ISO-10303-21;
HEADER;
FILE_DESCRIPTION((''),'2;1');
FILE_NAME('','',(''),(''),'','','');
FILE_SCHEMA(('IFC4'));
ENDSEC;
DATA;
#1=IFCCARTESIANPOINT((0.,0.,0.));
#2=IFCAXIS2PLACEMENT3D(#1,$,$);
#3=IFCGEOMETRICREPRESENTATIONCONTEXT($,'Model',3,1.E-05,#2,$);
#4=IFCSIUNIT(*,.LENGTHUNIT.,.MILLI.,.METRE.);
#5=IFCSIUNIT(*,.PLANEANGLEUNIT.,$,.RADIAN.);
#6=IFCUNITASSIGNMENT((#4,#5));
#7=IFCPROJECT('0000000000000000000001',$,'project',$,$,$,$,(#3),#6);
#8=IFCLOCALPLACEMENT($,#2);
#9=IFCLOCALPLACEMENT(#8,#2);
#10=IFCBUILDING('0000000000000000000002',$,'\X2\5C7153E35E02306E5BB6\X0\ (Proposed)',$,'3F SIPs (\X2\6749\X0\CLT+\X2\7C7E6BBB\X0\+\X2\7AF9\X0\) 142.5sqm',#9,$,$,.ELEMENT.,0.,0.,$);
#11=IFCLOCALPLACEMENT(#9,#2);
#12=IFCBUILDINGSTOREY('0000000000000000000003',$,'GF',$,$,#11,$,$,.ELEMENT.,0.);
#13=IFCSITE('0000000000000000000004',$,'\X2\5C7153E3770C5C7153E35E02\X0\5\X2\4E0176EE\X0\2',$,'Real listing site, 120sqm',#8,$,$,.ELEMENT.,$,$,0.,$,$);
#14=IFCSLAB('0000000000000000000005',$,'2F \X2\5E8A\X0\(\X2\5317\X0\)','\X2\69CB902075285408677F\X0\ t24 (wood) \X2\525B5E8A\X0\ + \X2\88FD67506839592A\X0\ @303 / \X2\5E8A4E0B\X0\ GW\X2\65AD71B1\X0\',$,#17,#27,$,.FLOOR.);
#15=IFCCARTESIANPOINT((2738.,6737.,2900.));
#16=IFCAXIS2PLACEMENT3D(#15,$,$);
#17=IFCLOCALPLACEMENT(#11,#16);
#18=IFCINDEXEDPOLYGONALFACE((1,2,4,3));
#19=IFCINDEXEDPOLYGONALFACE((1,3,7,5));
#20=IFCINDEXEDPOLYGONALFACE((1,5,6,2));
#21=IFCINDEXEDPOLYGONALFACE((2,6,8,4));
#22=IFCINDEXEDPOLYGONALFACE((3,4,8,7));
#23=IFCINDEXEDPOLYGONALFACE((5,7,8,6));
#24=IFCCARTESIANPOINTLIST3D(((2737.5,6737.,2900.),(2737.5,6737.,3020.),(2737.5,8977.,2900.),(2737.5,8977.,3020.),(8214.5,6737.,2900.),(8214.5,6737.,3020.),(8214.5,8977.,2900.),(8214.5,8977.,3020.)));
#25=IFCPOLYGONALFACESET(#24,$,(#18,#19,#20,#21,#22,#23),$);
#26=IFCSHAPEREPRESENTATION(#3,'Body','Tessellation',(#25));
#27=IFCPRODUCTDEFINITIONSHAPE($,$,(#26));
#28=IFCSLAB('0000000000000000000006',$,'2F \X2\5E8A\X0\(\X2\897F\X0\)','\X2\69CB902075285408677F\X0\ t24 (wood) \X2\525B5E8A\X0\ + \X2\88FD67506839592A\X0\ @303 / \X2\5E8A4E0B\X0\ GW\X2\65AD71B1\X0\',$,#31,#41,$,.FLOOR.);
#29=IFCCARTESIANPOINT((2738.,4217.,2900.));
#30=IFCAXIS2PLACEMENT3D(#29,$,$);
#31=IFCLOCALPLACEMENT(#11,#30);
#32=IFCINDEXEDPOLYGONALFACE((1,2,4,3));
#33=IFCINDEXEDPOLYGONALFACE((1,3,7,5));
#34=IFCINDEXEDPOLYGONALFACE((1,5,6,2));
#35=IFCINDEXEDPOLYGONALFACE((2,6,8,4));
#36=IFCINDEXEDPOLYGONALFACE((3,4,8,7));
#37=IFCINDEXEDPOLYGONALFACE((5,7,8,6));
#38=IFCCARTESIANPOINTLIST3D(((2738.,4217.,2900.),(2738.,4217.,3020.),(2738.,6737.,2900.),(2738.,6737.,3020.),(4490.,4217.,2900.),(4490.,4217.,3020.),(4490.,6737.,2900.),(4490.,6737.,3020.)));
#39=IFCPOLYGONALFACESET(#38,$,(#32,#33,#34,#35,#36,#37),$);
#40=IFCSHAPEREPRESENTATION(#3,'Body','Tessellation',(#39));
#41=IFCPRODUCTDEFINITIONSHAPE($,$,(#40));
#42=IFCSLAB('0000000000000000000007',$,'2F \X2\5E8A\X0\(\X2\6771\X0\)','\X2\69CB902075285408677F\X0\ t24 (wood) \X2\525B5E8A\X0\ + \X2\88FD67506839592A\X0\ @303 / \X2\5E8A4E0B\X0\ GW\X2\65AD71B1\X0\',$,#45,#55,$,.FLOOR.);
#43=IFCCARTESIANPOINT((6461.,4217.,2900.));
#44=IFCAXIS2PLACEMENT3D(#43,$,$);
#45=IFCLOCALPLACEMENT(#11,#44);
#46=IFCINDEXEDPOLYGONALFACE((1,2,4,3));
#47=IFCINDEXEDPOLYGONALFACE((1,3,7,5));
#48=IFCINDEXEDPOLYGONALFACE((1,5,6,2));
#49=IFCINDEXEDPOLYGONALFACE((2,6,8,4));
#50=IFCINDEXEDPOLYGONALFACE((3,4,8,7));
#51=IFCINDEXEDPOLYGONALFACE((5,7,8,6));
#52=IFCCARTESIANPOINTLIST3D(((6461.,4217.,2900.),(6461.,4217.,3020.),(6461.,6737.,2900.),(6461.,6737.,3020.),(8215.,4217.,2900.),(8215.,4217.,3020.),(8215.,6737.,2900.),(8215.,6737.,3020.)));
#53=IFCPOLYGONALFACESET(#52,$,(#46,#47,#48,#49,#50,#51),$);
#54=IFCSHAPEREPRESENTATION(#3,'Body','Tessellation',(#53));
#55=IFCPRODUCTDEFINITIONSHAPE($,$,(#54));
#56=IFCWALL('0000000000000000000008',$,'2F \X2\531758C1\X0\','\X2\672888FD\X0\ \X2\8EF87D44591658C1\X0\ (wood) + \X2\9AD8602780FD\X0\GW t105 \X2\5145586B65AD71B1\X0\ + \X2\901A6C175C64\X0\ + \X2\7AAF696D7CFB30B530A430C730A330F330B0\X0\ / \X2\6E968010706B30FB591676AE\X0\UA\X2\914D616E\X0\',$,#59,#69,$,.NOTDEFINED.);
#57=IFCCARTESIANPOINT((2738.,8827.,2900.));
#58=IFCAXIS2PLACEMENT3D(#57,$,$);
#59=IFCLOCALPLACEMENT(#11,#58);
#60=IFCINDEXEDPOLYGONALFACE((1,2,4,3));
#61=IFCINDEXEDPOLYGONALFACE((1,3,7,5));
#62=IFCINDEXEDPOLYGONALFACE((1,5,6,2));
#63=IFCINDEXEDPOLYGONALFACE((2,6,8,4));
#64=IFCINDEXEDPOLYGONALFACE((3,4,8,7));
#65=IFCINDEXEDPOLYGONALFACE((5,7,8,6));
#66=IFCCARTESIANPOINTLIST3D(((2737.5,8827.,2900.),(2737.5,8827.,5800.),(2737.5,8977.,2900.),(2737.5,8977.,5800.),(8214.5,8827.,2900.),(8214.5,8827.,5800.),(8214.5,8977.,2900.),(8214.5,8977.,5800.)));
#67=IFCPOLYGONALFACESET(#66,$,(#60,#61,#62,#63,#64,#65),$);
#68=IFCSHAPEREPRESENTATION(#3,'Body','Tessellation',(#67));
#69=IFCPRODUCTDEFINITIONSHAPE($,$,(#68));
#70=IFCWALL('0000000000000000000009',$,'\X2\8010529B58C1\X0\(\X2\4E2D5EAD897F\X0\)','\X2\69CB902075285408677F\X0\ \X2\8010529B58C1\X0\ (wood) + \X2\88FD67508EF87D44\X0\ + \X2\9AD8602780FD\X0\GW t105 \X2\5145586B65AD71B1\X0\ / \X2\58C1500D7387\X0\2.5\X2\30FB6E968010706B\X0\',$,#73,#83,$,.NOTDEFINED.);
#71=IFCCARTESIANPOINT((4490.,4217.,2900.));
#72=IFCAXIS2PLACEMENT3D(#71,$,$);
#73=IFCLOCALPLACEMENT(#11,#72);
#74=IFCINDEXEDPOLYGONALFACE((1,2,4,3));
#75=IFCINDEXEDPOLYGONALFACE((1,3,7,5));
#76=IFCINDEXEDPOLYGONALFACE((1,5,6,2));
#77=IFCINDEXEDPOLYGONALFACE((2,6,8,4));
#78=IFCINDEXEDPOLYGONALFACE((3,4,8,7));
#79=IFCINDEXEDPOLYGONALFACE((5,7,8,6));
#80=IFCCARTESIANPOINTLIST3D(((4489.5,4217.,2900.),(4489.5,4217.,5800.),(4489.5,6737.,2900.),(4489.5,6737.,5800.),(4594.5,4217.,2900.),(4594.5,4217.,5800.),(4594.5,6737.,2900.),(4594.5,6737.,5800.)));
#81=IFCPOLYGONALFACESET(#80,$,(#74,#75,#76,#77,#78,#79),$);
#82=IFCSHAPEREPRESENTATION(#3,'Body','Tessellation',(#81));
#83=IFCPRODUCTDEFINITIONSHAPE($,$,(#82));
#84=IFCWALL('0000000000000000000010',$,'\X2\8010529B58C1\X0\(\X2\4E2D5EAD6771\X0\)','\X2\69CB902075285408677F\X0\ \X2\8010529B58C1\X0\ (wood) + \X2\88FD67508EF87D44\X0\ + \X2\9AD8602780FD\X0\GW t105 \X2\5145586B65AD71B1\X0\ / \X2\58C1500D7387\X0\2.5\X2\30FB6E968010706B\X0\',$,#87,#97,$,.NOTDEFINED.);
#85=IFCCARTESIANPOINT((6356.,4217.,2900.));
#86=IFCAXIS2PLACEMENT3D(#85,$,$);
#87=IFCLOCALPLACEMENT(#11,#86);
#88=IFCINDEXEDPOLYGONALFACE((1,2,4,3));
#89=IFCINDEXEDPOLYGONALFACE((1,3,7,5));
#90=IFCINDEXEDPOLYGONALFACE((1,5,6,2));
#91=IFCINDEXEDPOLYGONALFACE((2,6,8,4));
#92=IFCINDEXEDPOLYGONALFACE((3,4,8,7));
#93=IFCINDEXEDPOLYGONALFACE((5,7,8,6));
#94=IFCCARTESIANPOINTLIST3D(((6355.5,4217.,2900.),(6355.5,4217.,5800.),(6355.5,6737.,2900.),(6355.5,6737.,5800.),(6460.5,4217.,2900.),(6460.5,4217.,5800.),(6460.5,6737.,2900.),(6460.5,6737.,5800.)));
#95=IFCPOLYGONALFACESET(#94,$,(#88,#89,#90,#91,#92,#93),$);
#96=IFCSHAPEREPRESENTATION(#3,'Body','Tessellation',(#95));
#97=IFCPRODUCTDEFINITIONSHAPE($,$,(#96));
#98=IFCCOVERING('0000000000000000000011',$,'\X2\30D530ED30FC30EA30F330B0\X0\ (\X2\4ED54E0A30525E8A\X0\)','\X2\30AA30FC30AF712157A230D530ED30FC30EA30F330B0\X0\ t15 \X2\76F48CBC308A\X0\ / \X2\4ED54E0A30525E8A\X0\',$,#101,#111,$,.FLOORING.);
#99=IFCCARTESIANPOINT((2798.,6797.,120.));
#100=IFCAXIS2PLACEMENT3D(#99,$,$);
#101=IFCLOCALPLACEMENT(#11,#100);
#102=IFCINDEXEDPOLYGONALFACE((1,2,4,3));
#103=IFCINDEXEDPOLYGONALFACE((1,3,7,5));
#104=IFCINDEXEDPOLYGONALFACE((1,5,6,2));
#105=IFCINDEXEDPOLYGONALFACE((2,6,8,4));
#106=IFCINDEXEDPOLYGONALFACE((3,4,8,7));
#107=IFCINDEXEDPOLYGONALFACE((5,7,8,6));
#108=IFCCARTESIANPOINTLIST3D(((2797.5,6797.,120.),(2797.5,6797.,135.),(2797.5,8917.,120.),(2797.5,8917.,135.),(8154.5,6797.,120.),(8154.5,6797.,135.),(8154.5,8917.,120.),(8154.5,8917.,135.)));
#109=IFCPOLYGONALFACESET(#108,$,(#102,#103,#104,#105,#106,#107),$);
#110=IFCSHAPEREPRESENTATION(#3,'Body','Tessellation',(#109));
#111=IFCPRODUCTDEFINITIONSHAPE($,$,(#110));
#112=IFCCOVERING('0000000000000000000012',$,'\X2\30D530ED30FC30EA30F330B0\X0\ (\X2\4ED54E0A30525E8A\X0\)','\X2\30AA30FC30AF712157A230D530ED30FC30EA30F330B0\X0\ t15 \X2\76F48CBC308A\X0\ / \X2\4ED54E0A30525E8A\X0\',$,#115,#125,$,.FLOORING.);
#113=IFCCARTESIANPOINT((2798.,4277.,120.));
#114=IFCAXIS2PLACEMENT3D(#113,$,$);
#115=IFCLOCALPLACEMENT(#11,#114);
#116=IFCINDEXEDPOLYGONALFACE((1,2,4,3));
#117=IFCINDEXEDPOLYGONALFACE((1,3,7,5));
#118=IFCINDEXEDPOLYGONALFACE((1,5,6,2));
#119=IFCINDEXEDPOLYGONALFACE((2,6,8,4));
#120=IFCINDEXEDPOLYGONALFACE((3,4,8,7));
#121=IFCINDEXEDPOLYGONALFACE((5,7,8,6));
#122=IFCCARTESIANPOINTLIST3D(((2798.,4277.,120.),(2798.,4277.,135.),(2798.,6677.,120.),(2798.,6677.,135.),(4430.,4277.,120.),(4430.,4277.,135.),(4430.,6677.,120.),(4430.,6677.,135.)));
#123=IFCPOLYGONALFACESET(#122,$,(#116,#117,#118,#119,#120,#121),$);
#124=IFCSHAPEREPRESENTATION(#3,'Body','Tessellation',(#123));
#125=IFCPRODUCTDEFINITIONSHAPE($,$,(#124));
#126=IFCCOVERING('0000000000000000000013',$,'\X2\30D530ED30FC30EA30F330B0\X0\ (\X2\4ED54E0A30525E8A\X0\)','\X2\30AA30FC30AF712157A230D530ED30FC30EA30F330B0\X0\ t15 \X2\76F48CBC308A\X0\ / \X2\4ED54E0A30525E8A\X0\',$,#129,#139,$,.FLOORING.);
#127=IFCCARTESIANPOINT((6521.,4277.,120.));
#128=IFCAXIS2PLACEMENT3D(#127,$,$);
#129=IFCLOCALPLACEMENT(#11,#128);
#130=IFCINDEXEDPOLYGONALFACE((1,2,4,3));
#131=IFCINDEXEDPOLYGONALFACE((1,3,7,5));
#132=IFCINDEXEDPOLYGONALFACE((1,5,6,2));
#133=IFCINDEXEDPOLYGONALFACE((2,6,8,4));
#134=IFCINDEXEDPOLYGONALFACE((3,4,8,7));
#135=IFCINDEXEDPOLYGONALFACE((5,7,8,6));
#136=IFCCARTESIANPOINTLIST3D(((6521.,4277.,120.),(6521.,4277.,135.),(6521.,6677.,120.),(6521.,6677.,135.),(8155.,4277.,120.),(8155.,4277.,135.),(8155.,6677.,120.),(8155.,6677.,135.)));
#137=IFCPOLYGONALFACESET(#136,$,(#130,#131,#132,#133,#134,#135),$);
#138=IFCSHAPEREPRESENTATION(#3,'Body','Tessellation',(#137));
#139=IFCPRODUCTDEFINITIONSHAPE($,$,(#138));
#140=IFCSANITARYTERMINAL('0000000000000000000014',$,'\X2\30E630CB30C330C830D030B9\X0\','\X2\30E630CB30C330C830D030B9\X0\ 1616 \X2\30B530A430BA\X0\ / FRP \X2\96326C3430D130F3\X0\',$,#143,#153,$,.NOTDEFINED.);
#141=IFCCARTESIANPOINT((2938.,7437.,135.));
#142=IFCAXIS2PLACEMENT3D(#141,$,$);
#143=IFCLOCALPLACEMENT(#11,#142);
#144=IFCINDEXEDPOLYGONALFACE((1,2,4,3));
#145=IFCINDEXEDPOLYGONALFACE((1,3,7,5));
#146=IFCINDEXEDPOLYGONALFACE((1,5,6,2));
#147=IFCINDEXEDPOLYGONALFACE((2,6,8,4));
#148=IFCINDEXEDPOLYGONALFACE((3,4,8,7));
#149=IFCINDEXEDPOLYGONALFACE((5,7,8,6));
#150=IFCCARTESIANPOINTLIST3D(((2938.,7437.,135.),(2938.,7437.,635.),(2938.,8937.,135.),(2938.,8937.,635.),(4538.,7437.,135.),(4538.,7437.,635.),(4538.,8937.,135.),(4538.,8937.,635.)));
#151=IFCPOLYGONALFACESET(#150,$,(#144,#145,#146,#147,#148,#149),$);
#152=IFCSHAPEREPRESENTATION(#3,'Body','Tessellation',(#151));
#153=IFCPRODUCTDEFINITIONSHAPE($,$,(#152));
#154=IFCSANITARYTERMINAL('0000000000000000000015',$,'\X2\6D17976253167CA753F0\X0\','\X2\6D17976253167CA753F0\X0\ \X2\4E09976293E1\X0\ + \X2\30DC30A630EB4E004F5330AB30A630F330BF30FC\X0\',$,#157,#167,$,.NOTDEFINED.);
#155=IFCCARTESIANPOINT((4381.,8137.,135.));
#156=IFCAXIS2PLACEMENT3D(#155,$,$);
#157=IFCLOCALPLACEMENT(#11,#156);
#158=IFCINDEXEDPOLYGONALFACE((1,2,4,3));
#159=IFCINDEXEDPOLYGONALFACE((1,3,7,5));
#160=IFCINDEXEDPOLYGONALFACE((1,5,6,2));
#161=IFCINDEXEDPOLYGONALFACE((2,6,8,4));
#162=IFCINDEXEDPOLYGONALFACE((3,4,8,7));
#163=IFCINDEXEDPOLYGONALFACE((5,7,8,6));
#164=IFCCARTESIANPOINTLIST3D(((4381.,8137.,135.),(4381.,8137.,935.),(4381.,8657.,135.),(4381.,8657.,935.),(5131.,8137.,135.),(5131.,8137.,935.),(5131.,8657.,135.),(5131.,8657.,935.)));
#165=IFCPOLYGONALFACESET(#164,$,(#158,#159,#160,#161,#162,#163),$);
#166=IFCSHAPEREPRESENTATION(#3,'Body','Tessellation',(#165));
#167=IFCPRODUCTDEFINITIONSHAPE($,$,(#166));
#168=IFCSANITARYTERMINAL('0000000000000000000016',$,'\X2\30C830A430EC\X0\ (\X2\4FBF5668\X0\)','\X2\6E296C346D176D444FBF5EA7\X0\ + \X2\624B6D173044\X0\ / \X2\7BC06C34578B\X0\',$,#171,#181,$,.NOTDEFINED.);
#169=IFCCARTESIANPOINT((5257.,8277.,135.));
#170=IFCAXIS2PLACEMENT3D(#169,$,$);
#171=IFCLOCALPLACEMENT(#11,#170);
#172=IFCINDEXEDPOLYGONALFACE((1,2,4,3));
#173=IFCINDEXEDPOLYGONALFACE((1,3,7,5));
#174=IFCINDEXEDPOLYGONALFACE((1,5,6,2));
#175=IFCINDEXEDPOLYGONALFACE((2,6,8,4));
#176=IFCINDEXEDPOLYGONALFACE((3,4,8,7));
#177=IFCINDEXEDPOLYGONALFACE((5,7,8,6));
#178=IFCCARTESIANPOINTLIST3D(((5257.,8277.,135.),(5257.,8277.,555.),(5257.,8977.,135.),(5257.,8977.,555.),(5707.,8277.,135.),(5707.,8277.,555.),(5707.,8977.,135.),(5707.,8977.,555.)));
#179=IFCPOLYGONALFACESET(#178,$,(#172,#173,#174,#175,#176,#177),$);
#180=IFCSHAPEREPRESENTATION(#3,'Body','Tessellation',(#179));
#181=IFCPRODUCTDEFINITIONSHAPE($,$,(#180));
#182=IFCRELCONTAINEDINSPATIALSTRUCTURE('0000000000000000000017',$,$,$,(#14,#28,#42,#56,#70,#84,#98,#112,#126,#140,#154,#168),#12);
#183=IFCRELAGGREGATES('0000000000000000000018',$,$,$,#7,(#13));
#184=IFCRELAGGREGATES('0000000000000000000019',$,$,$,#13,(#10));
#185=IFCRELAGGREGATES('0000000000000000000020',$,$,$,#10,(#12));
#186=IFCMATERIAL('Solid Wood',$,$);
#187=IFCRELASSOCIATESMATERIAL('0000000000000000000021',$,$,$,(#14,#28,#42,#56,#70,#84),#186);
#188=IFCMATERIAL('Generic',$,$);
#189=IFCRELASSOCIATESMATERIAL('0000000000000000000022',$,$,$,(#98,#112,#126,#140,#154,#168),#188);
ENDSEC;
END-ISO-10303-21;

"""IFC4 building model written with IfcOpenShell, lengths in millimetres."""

from ifc_helpers import new_model, si_unit, frame, frame_2d, origin, place, context, project, spatial, rectangle, extrude, material, element, save


model = new_model("IFC4")

# Units and contexts
model_context = context("Model", 3, precision=1e-05, world=origin())
ifc_project = project(units=[si_unit("LENGTHUNIT", "METRE", prefix="MILLI"), si_unit("PLANEANGLEUNIT", "RADIAN")], contexts=[model_context])

# Site, building, storey
site_placement = place(None, origin())
site = spatial("IfcSite", under=ifc_project, at=site_placement, Name="山口県山口市5丁目2", ObjectType="Real listing site, 120sqm", CompositionType="ELEMENT", RefElevation=0.0)
building_placement = place(site_placement, origin())
building = spatial("IfcBuilding", under=site, at=building_placement, Name="山口市の家 (Proposed)", ObjectType="3F SIPs (杉CLT+籾殻+竹) 142.5sqm", CompositionType="ELEMENT", ElevationOfRefHeight=0.0, ElevationOfTerrain=0.0)
storey_placement = place(building_placement, origin())
storey = spatial("IfcBuildingStorey", under=building, at=storey_placement, Name="GF", CompositionType="ELEMENT", Elevation=0.0)

# Slabs
ifc_material_1 = material(Name="Solid Wood")
slab_1_placement = place(storey_placement, frame((2738.0, 6737.0, 2900.0)))
element("IfcSlab", 1, at=slab_1_placement, inside=storey, material=ifc_material_1, Name="2F 床(北)", Description="構造用合板 t24 (wood) 剛床 + 製材根太 @303 / 床下 GW断熱", PredefinedType="FLOOR", context=model_context, shape_type="SweptSolid", body=[
    extrude(rectangle(XDim=5477.0, YDim=2240.0, at=frame_2d((2738.0, 1120.0))), frame((2738.0, 6737.0, 2900.0)), (0.0, 0.0, 1.0), 120.0),
])
slab_2_placement = place(storey_placement, frame((2738.0, 4217.0, 2900.0)))
element("IfcSlab", 2, at=slab_2_placement, inside=storey, material=ifc_material_1, Name="2F 床(西)", Description="構造用合板 t24 (wood) 剛床 + 製材根太 @303 / 床下 GW断熱", PredefinedType="FLOOR", context=model_context, shape_type="SweptSolid", body=[
    extrude(rectangle(XDim=1752.0, YDim=2520.0, at=frame_2d((876.0, 1260.0))), frame((2738.0, 4217.0, 2900.0)), (0.0, 0.0, 1.0), 120.0),
])
slab_3_placement = place(storey_placement, frame((6461.0, 4217.0, 2900.0)))
element("IfcSlab", 3, at=slab_3_placement, inside=storey, material=ifc_material_1, Name="2F 床(東)", Description="構造用合板 t24 (wood) 剛床 + 製材根太 @303 / 床下 GW断熱", PredefinedType="FLOOR", context=model_context, shape_type="SweptSolid", body=[
    extrude(rectangle(XDim=1754.0, YDim=2520.0, at=frame_2d((877.0, 1260.0))), frame((6461.0, 4217.0, 2900.0)), (0.0, 0.0, 1.0), 120.0),
])

# Wall
wall_1_placement = place(storey_placement, frame((2738.0, 8827.0, 2900.0)))
element("IfcWall", 4, at=wall_1_placement, inside=storey, material=ifc_material_1, Name="2F 北壁", Description="木製 軸組外壁 (wood) + 高性能GW t105 充填断熱 + 通気層 + 窯業系サイディング / 準耐火・外皮UA配慮", PredefinedType="NOTDEFINED", context=model_context, shape_type="SweptSolid", body=[
    extrude(rectangle(XDim=5477.0, YDim=150.0, at=frame_2d((2738.0, 75.0))), frame((2738.0, 8827.0, 2900.0)), (0.0, 0.0, 1.0), 2900.0),
])

# Walls
wall_2_placement = place(storey_placement, frame((4490.0, 4217.0, 2900.0)))
element("IfcWall", 5, at=wall_2_placement, inside=storey, material=ifc_material_1, Name="耐力壁(中庭西)", Description="構造用合板 耐力壁 (wood) + 製材軸組 + 高性能GW t105 充填断熱 / 壁倍率2.5・準耐火", PredefinedType="NOTDEFINED", context=model_context, shape_type="SweptSolid", body=[
    extrude(rectangle(XDim=105.0, YDim=2520.0, at=frame_2d((52.0, 1260.0))), frame((4490.0, 4217.0, 2900.0)), (0.0, 0.0, 1.0), 2900.0),
])
wall_3_placement = place(storey_placement, frame((6356.0, 4217.0, 2900.0)))
element("IfcWall", 6, at=wall_3_placement, inside=storey, material=ifc_material_1, Name="耐力壁(中庭東)", Description="構造用合板 耐力壁 (wood) + 製材軸組 + 高性能GW t105 充填断熱 / 壁倍率2.5・準耐火", PredefinedType="NOTDEFINED", context=model_context, shape_type="SweptSolid", body=[
    extrude(rectangle(XDim=105.0, YDim=2520.0, at=frame_2d((52.0, 1260.0))), frame((6356.0, 4217.0, 2900.0)), (0.0, 0.0, 1.0), 2900.0),
])

# Coverings
ifc_material_2 = material(Name="Generic")
covering_1_placement = place(storey_placement, frame((2798.0, 6797.0, 120.0)))
element("IfcCovering", 7, at=covering_1_placement, inside=storey, material=ifc_material_2, Name="フローリング (仕上げ床)", Description="オーク無垢フローリング t15 直貼り / 仕上げ床", PredefinedType="FLOORING", context=model_context, shape_type="SweptSolid", body=[
    extrude(rectangle(XDim=5357.0, YDim=2120.0, at=frame_2d((2678.0, 1060.0))), frame((2798.0, 6797.0, 120.0)), (0.0, 0.0, 1.0), 15.0),
])
covering_2_placement = place(storey_placement, frame((2798.0, 4277.0, 120.0)))
element("IfcCovering", 8, at=covering_2_placement, inside=storey, material=ifc_material_2, Name="フローリング (仕上げ床)", Description="オーク無垢フローリング t15 直貼り / 仕上げ床", PredefinedType="FLOORING", context=model_context, shape_type="SweptSolid", body=[
    extrude(rectangle(XDim=1632.0, YDim=2400.0, at=frame_2d((816.0, 1200.0))), frame((2798.0, 4277.0, 120.0)), (0.0, 0.0, 1.0), 15.0),
])
covering_3_placement = place(storey_placement, frame((6521.0, 4277.0, 120.0)))
element("IfcCovering", 9, at=covering_3_placement, inside=storey, material=ifc_material_2, Name="フローリング (仕上げ床)", Description="オーク無垢フローリング t15 直貼り / 仕上げ床", PredefinedType="FLOORING", context=model_context, shape_type="SweptSolid", body=[
    extrude(rectangle(XDim=1634.0, YDim=2400.0, at=frame_2d((817.0, 1200.0))), frame((6521.0, 4277.0, 120.0)), (0.0, 0.0, 1.0), 15.0),
])

# Sanitary terminals
sanitary_terminal_1_placement = place(storey_placement, frame((2938.0, 7437.0, 135.0)))
element("IfcSanitaryTerminal", 10, at=sanitary_terminal_1_placement, inside=storey, material=ifc_material_2, Name="ユニットバス", Description="ユニットバス 1616 サイズ / FRP 防水パン", PredefinedType="NOTDEFINED", context=model_context, shape_type="SweptSolid", body=[
    extrude(rectangle(XDim=1600.0, YDim=1500.0, at=frame_2d((800.0, 750.0))), frame((2938.0, 7437.0, 135.0)), (0.0, 0.0, 1.0), 500.0),
])
sanitary_terminal_2_placement = place(storey_placement, frame((4381.0, 8137.0, 135.0)))
element("IfcSanitaryTerminal", 11, at=sanitary_terminal_2_placement, inside=storey, material=ifc_material_2, Name="洗面化粧台", Description="洗面化粧台 三面鏡 + ボウル一体カウンター", PredefinedType="NOTDEFINED", context=model_context, shape_type="SweptSolid", body=[
    extrude(rectangle(XDim=750.0, YDim=520.0, at=frame_2d((375.0, 260.0))), frame((4381.0, 8137.0, 135.0)), (0.0, 0.0, 1.0), 800.0),
])
sanitary_terminal_3_placement = place(storey_placement, frame((5257.0, 8277.0, 135.0)))
element("IfcSanitaryTerminal", 12, at=sanitary_terminal_3_placement, inside=storey, material=ifc_material_2, Name="トイレ (便器)", Description="温水洗浄便座 + 手洗い / 節水型", PredefinedType="NOTDEFINED", context=model_context, shape_type="SweptSolid", body=[
    extrude(rectangle(XDim=450.0, YDim=700.0, at=frame_2d((225.0, 350.0))), frame((5257.0, 8277.0, 135.0)), (0.0, 0.0, 1.0), 420.0),
])

save(model, "model.ifc")
